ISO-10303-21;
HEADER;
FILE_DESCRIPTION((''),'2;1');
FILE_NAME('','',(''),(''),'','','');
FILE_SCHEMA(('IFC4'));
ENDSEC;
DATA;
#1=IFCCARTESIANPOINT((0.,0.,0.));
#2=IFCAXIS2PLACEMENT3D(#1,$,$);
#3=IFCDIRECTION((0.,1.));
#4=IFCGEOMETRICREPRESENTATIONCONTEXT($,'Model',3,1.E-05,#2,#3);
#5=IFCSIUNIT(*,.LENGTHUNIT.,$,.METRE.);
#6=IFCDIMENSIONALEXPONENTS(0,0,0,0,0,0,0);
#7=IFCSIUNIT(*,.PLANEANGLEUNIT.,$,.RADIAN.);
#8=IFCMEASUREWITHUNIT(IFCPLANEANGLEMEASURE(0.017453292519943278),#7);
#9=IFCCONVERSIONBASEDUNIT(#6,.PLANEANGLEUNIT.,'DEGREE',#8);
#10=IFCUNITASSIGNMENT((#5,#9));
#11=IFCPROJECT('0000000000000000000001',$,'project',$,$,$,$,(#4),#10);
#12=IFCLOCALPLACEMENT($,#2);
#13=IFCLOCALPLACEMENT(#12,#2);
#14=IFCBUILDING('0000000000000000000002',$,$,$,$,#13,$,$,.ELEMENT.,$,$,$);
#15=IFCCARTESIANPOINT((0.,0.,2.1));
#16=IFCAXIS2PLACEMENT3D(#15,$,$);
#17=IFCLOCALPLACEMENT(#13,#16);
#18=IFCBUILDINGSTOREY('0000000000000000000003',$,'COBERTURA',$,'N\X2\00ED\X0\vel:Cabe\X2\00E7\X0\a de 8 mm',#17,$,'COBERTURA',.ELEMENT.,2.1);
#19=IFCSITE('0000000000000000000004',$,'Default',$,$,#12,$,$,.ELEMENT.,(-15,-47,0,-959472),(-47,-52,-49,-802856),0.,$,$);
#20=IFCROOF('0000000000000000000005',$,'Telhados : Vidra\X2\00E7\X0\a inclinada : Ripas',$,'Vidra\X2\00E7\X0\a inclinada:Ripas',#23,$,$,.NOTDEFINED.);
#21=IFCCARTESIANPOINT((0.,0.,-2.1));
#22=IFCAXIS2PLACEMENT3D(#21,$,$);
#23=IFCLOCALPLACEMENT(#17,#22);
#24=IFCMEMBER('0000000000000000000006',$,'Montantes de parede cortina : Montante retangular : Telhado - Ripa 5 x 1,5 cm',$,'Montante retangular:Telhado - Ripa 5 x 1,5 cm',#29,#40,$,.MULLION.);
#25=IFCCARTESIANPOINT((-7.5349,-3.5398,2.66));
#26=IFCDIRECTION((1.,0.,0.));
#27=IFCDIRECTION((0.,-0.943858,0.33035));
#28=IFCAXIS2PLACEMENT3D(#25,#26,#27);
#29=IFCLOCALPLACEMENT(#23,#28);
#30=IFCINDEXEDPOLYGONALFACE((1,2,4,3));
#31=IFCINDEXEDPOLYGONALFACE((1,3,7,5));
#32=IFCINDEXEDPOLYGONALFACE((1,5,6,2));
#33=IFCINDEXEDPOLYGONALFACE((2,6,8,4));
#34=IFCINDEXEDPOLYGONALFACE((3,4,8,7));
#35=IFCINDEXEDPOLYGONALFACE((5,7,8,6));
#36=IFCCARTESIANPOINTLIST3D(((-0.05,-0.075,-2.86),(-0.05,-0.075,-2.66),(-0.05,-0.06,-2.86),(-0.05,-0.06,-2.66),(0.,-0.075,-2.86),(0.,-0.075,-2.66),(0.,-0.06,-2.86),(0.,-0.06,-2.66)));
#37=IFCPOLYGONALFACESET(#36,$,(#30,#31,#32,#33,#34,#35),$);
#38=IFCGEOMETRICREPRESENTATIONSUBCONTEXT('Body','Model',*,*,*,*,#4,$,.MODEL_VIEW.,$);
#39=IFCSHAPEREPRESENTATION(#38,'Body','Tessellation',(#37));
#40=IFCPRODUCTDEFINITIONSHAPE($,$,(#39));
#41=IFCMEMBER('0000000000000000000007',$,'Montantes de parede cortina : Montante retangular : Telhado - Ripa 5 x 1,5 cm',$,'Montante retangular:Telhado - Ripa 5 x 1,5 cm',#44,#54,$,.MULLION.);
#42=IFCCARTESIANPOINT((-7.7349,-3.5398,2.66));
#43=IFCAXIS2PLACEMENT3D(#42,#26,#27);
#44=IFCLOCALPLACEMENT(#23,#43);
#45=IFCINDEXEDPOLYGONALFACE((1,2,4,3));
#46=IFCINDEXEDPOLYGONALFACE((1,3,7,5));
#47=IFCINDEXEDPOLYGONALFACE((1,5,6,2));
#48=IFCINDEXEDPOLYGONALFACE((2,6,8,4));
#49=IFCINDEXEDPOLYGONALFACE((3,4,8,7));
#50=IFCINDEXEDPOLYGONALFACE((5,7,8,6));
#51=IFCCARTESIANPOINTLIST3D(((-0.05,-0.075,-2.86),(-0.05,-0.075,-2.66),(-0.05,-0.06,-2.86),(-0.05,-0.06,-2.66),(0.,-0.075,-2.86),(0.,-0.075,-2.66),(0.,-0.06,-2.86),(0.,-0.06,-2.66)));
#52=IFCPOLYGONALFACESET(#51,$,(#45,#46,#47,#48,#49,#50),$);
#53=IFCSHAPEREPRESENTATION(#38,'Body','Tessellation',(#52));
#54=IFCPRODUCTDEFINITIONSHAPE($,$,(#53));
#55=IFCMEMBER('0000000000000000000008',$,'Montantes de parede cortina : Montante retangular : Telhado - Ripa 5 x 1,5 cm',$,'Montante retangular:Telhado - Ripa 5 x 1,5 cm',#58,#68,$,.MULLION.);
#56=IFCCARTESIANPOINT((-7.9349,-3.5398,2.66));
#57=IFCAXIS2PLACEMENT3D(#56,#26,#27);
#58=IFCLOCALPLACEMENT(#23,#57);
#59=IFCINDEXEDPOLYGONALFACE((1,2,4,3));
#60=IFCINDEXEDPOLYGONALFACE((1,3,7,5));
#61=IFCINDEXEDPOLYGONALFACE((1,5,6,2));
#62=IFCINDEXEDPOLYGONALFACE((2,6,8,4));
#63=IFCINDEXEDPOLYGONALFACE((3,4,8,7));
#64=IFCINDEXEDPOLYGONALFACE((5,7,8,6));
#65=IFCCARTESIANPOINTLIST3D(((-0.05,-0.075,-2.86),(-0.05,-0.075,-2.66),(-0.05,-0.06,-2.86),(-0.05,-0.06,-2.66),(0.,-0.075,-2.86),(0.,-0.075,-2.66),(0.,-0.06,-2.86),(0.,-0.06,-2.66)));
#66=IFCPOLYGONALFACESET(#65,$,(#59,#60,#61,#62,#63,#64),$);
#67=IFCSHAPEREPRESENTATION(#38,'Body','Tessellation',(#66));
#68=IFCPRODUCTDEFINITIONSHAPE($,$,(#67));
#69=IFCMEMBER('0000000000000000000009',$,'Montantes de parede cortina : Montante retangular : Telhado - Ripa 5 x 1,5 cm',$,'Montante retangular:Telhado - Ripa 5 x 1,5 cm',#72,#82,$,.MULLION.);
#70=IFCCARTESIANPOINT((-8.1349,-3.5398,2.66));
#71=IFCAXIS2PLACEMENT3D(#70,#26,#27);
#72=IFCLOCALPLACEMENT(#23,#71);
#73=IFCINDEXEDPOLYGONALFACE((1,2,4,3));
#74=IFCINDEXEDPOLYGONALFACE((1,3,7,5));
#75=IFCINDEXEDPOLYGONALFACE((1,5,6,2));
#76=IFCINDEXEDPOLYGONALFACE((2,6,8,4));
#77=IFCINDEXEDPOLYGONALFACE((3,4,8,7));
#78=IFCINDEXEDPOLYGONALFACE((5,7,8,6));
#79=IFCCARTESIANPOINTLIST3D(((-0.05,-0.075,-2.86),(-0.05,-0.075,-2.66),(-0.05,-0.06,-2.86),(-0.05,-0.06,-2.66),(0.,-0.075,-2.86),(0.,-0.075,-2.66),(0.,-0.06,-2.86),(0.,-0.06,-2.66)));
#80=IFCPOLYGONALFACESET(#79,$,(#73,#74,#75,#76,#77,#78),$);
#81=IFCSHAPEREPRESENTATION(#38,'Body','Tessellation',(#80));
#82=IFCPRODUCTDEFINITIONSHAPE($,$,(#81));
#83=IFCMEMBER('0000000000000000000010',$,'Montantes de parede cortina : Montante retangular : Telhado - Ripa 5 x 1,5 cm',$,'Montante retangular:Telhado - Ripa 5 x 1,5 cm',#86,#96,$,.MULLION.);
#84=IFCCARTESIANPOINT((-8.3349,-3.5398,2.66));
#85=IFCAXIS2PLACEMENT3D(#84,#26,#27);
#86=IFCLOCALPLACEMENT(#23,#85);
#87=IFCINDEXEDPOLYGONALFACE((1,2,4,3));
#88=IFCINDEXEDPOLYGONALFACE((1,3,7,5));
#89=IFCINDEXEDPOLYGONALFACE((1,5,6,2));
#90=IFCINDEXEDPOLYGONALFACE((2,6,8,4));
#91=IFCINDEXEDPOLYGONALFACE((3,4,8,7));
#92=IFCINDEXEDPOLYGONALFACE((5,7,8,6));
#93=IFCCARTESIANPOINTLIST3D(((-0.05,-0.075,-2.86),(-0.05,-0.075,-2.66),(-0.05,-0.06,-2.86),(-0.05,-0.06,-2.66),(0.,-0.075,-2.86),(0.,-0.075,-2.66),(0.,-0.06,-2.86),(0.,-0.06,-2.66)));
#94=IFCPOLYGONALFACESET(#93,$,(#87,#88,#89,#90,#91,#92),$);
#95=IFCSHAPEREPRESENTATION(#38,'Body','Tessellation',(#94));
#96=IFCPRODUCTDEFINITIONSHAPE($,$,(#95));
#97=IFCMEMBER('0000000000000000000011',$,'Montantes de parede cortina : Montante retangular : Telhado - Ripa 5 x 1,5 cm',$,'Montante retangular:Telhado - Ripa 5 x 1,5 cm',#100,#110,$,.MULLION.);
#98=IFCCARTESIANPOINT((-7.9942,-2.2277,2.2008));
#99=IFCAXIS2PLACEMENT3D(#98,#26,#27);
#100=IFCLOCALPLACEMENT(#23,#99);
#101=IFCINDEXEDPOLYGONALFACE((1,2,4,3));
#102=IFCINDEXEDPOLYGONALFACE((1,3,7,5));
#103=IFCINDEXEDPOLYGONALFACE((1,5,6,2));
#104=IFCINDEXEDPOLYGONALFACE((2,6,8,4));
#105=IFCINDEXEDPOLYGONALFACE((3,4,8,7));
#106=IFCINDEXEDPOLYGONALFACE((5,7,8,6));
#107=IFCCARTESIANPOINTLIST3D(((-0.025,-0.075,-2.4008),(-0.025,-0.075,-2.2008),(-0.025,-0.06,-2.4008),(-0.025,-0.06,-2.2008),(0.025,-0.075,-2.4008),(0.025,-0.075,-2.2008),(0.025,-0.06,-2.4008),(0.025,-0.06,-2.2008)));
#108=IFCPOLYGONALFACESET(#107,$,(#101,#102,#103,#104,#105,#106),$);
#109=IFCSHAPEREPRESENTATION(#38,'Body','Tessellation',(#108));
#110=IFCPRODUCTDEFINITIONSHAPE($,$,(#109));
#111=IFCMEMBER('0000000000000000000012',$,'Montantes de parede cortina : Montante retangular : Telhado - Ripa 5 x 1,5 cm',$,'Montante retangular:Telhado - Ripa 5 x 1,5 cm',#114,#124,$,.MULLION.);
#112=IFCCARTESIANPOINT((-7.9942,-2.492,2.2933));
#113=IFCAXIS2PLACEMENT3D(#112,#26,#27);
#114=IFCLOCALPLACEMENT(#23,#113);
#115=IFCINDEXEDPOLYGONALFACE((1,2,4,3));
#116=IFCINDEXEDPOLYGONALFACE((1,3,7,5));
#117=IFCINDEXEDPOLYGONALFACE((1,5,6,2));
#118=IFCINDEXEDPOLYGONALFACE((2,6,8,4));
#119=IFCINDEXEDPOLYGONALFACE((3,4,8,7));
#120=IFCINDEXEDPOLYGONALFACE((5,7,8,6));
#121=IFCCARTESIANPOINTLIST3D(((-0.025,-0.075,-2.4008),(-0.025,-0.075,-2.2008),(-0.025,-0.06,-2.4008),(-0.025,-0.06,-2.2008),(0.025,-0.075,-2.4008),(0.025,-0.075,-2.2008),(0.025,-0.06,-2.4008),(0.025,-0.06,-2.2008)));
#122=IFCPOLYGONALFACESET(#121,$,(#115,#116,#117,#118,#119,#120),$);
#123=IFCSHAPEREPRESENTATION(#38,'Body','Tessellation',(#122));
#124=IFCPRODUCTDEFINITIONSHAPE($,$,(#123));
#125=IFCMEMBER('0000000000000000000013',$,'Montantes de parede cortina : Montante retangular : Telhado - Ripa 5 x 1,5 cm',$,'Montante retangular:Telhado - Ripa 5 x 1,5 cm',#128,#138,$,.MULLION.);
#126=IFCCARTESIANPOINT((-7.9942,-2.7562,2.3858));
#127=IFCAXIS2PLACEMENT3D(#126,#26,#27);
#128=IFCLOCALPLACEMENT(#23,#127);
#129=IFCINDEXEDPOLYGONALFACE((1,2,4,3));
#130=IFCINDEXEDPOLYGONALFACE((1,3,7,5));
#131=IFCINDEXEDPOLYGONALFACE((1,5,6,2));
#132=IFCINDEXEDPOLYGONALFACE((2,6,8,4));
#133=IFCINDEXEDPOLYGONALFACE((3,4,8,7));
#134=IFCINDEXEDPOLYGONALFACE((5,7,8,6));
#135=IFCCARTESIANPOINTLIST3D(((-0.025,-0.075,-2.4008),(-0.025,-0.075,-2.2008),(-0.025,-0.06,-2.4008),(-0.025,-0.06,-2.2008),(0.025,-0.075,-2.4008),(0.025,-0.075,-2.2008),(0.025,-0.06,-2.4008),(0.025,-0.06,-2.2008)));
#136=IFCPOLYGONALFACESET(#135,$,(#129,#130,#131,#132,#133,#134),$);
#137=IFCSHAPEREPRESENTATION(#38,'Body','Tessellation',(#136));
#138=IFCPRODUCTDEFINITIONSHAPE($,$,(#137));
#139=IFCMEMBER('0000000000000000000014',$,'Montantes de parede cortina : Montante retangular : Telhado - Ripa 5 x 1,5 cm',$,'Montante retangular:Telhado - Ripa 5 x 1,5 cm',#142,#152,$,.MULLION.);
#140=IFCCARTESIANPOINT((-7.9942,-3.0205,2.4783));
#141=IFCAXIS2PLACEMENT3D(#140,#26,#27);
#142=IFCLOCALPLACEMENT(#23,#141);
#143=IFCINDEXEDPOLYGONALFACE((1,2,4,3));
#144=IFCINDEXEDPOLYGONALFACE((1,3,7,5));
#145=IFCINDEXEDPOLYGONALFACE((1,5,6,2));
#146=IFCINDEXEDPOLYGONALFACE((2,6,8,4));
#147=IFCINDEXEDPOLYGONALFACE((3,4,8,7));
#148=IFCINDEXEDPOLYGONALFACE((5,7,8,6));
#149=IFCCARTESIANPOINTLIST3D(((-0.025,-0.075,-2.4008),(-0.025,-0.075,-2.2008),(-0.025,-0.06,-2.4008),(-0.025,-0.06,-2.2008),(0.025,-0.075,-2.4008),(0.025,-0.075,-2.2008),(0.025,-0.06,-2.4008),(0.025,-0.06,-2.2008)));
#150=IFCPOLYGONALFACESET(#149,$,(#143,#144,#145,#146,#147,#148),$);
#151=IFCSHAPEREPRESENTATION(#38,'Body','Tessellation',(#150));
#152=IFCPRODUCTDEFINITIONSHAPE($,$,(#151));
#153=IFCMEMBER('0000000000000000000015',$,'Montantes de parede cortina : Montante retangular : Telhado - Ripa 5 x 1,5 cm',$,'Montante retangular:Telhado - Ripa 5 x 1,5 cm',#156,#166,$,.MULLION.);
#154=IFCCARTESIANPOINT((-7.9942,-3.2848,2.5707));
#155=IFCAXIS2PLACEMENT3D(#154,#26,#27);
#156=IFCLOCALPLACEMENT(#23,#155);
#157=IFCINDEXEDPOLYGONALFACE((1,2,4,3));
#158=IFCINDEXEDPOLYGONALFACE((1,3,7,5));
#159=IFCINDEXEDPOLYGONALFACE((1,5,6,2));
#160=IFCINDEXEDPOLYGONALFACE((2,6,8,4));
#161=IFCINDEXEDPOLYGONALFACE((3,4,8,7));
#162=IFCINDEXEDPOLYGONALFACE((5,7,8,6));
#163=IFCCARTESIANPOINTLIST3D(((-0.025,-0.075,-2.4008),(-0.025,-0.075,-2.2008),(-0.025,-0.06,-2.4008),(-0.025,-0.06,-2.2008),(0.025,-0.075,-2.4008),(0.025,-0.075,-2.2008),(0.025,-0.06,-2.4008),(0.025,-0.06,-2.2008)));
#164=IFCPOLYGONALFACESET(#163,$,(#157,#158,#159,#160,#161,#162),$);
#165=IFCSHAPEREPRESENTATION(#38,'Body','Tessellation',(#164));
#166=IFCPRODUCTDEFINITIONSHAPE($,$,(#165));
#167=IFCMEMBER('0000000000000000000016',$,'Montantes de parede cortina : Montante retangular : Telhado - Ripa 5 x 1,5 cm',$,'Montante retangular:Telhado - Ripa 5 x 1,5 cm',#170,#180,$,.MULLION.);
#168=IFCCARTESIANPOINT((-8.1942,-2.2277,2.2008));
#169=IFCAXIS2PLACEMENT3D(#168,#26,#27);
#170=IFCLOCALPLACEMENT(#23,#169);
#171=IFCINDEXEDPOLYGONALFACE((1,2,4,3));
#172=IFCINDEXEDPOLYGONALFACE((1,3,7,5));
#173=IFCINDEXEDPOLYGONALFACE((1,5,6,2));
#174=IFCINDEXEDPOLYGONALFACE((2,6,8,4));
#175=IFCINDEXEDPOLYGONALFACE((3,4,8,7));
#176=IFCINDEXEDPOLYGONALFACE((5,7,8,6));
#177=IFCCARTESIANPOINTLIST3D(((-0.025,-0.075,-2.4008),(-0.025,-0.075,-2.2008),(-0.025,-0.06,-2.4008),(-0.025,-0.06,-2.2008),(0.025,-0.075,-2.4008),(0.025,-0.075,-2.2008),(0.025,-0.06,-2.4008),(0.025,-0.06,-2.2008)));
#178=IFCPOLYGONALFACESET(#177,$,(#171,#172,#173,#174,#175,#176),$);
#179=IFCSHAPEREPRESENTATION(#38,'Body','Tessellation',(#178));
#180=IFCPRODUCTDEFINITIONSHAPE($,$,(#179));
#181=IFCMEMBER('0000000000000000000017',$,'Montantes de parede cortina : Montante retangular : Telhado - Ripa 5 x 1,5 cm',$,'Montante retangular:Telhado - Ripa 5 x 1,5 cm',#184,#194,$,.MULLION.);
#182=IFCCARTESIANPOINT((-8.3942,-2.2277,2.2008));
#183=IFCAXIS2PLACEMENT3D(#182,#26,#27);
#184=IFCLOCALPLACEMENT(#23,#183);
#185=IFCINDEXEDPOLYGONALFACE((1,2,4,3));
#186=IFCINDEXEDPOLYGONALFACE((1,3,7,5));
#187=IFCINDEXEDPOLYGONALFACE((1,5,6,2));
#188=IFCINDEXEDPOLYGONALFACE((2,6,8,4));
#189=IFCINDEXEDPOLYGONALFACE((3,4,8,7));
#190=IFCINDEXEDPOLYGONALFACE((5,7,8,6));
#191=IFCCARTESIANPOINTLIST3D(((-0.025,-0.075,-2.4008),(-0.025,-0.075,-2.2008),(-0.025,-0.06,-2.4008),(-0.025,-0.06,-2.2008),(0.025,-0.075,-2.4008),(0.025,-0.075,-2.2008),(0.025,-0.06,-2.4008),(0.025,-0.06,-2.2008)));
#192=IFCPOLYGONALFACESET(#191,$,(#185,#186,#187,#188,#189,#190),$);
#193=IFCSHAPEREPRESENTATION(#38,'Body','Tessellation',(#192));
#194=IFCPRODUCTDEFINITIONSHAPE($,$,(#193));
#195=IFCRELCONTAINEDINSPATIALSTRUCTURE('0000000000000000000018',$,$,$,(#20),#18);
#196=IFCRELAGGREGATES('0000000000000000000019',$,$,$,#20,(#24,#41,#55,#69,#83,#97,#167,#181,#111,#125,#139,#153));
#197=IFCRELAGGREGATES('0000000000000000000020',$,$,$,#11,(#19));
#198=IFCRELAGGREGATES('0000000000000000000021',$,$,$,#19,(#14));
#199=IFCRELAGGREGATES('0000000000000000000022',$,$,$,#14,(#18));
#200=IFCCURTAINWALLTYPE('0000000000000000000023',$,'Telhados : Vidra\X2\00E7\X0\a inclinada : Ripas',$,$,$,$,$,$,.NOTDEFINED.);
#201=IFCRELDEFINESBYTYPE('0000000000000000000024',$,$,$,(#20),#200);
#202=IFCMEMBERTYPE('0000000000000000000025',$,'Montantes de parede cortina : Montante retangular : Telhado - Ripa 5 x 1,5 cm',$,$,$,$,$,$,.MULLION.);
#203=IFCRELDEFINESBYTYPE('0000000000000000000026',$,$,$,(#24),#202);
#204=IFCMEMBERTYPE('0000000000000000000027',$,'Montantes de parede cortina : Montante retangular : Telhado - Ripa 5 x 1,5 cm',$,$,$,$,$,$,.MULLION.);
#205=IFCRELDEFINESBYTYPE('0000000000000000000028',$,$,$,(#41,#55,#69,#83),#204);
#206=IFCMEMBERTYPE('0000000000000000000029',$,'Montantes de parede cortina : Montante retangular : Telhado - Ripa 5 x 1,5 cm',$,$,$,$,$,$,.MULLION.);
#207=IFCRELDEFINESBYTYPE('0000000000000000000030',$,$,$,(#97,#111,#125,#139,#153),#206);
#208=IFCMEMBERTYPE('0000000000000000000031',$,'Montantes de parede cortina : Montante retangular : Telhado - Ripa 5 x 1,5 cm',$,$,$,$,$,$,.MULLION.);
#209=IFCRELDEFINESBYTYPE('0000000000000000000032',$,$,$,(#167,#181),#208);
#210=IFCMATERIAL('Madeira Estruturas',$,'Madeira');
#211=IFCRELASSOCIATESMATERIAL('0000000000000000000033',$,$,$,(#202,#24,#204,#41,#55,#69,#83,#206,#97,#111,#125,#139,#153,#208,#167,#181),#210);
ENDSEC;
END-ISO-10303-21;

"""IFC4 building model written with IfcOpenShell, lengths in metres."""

from ifc_helpers import new_model, entity, si_unit, converted_unit, direction, frame, origin, place, context, subcontext, project, spatial, indexed_curve, outline, extrude, source, transform, mapped, material, type_object, type_shapes, element, aggregate, save


model = new_model("IFC4")

# Units and contexts
model_context = context("Model", 3, precision=1e-05, world=origin(), true_north=direction((0.0, 1.0)))
body_context = subcontext(model_context, "Body", "Model", "MODEL_VIEW")
ifc_project = project(units=[si_unit("LENGTHUNIT", "METRE"), converted_unit("PLANEANGLEUNIT", "DEGREE", entity("IfcPlaneAngleMeasure", 0.017453292519943278), si_unit("PLANEANGLEUNIT", "RADIAN"), dimensions=[0, 0, 0, 0, 0, 0, 0])], contexts=[model_context])

# Site, building, storey
site_placement = place(None, origin())
site = spatial("IfcSite", under=ifc_project, at=site_placement, Name="Default", CompositionType="ELEMENT", RefLatitude=(-15, -47, 0, -959472), RefLongitude=(-47, -52, -49, -802856), RefElevation=0.0)
building_placement = place(site_placement, origin())
building = spatial("IfcBuilding", under=site, at=building_placement, CompositionType="ELEMENT")
storey_placement = place(building_placement, frame((0.0, 0.0, 2.1)))
storey = spatial("IfcBuildingStorey", under=building, at=storey_placement, Name="COBERTURA", ObjectType="Nível:Cabeça de 8 mm", LongName="COBERTURA", CompositionType="ELEMENT", Elevation=2.1)

# Roof, members
curtain_wall_type = type_object("IfcCurtainWallType", Name="Telhados : Vidraça inclinada : Ripas", PredefinedType="NOTDEFINED")
roof_placement = place(storey_placement, frame((0.0, 0.0, -2.1)))
roof = element("IfcRoof", 1, at=roof_placement, inside=storey, type_object=curtain_wall_type, Name="Telhados : Vidraça inclinada : Ripas", ObjectType="Vidraça inclinada:Ripas", PredefinedType="NOTDEFINED")
ifc_material_1 = material(Name="Madeira Estruturas", Category="Madeira")
member_type_1 = type_object("IfcMemberType", Name="Montantes de parede cortina : Montante retangular : Telhado - Ripa 5 x 1,5 cm", PredefinedType="MULLION", material=ifc_material_1)
shared_shape_1 = source(origin(), body_context, "Body", "SweptSolid", [
    extrude(outline(indexed_curve([(-0.025, -0.0075), (0.025, -0.0075), (0.025, 0.0075), (-0.025, 0.0075), (-0.025, -0.0075)], self_intersect=False)), frame((-0.025, -0.0675, -2.86), z_axis=(0.0, 0.0, 1.0), x_axis=(-1.0, 0.0, 0.0)), (0.0, 0.0, 1.0), 0.2),
])
type_shapes(member_type_1, [shared_shape_1])
member_1_placement = place(roof_placement, frame((-7.5349, -3.5398, 2.66), z_axis=(1.0, 0.0, 0.0), x_axis=(0.0, -0.943858, 0.33035)))
member_1 = element("IfcMember", 2, at=member_1_placement, type_object=member_type_1, material=ifc_material_1, Name="Montantes de parede cortina : Montante retangular : Telhado - Ripa 5 x 1,5 cm", ObjectType="Montante retangular:Telhado - Ripa 5 x 1,5 cm", PredefinedType="MULLION", context=body_context, shape_type="MappedRepresentation", body=[
    mapped(shared_shape_1, transform((0.0, 0.0, 0.0), scale=1.0)),
])
member_type_2 = type_object("IfcMemberType", Name="Montantes de parede cortina : Montante retangular : Telhado - Ripa 5 x 1,5 cm", PredefinedType="MULLION", material=ifc_material_1)
shared_shape_2 = source(origin(), body_context, "Body", "SweptSolid", [
    extrude(outline(indexed_curve([(-0.025, -0.0075), (0.025, -0.0075), (0.025, 0.0075), (-0.025, 0.0075), (-0.025, -0.0075)], self_intersect=False)), frame((-0.025, -0.0675, -2.86), z_axis=(0.0, 0.0, 1.0), x_axis=(-1.0, 0.0, 0.0)), (0.0, 0.0, 1.0), 0.2),
])
type_shapes(member_type_2, [shared_shape_2])
member_2_placement = place(roof_placement, frame((-7.7349, -3.5398, 2.66), z_axis=(1.0, 0.0, 0.0), x_axis=(0.0, -0.943858, 0.33035)))
member_2 = element("IfcMember", 3, at=member_2_placement, type_object=member_type_2, material=ifc_material_1, Name="Montantes de parede cortina : Montante retangular : Telhado - Ripa 5 x 1,5 cm", ObjectType="Montante retangular:Telhado - Ripa 5 x 1,5 cm", PredefinedType="MULLION", context=body_context, shape_type="MappedRepresentation", body=[
    mapped(shared_shape_2, transform((0.0, 0.0, 0.0), scale=1.0)),
])
member_3_placement = place(roof_placement, frame((-7.9349, -3.5398, 2.66), z_axis=(1.0, 0.0, 0.0), x_axis=(0.0, -0.943858, 0.33035)))
member_3 = element("IfcMember", 4, at=member_3_placement, type_object=member_type_2, material=ifc_material_1, Name="Montantes de parede cortina : Montante retangular : Telhado - Ripa 5 x 1,5 cm", ObjectType="Montante retangular:Telhado - Ripa 5 x 1,5 cm", PredefinedType="MULLION", context=body_context, shape_type="MappedRepresentation", body=[
    mapped(shared_shape_2, transform((0.0, 0.0, 0.0), scale=1.0)),
])
member_4_placement = place(roof_placement, frame((-8.1349, -3.5398, 2.66), z_axis=(1.0, 0.0, 0.0), x_axis=(0.0, -0.943858, 0.33035)))
member_4 = element("IfcMember", 5, at=member_4_placement, type_object=member_type_2, material=ifc_material_1, Name="Montantes de parede cortina : Montante retangular : Telhado - Ripa 5 x 1,5 cm", ObjectType="Montante retangular:Telhado - Ripa 5 x 1,5 cm", PredefinedType="MULLION", context=body_context, shape_type="MappedRepresentation", body=[
    mapped(shared_shape_2, transform((0.0, 0.0, 0.0), scale=1.0)),
])
member_5_placement = place(roof_placement, frame((-8.3349, -3.5398, 2.66), z_axis=(1.0, 0.0, 0.0), x_axis=(0.0, -0.943858, 0.33035)))
member_5 = element("IfcMember", 6, at=member_5_placement, type_object=member_type_2, material=ifc_material_1, Name="Montantes de parede cortina : Montante retangular : Telhado - Ripa 5 x 1,5 cm", ObjectType="Montante retangular:Telhado - Ripa 5 x 1,5 cm", PredefinedType="MULLION", context=body_context, shape_type="MappedRepresentation", body=[
    mapped(shared_shape_2, transform((0.0, 0.0, 0.0), scale=1.0)),
])
member_type_3 = type_object("IfcMemberType", Name="Montantes de parede cortina : Montante retangular : Telhado - Ripa 5 x 1,5 cm", PredefinedType="MULLION", material=ifc_material_1)
shared_shape_3 = source(origin(), body_context, "Body", "SweptSolid", [
    extrude(outline(indexed_curve([(-0.025, -0.0075), (0.025, -0.0075), (0.025, 0.0075), (-0.025, 0.0075), (-0.025, -0.0075)], self_intersect=False)), frame((0.0, -0.0675, -2.4008), z_axis=(0.0, 0.0, 1.0), x_axis=(-1.0, 0.0, 0.0)), (0.0, 0.0, 1.0), 0.2),
])
type_shapes(member_type_3, [shared_shape_3])
member_6_placement = place(roof_placement, frame((-7.9942, -2.2277, 2.2008), z_axis=(1.0, 0.0, 0.0), x_axis=(0.0, -0.943858, 0.33035)))
member_6 = element("IfcMember", 7, at=member_6_placement, type_object=member_type_3, material=ifc_material_1, Name="Montantes de parede cortina : Montante retangular : Telhado - Ripa 5 x 1,5 cm", ObjectType="Montante retangular:Telhado - Ripa 5 x 1,5 cm", PredefinedType="MULLION", context=body_context, shape_type="MappedRepresentation", body=[
    mapped(shared_shape_3, transform((0.0, 0.0, 0.0), scale=1.0)),
])
member_7_placement = place(roof_placement, frame((-7.9942, -2.492, 2.2933), z_axis=(1.0, 0.0, 0.0), x_axis=(0.0, -0.943858, 0.33035)))
member_7 = element("IfcMember", 8, at=member_7_placement, type_object=member_type_3, material=ifc_material_1, Name="Montantes de parede cortina : Montante retangular : Telhado - Ripa 5 x 1,5 cm", ObjectType="Montante retangular:Telhado - Ripa 5 x 1,5 cm", PredefinedType="MULLION", context=body_context, shape_type="MappedRepresentation", body=[
    mapped(shared_shape_3, transform((0.0, 0.0, 0.0), scale=1.0)),
])
member_8_placement = place(roof_placement, frame((-7.9942, -2.7562, 2.3858), z_axis=(1.0, 0.0, 0.0), x_axis=(0.0, -0.943858, 0.33035)))
member_8 = element("IfcMember", 9, at=member_8_placement, type_object=member_type_3, material=ifc_material_1, Name="Montantes de parede cortina : Montante retangular : Telhado - Ripa 5 x 1,5 cm", ObjectType="Montante retangular:Telhado - Ripa 5 x 1,5 cm", PredefinedType="MULLION", context=body_context, shape_type="MappedRepresentation", body=[
    mapped(shared_shape_3, transform((0.0, 0.0, 0.0), scale=1.0)),
])
member_9_placement = place(roof_placement, frame((-7.9942, -3.0205, 2.4783), z_axis=(1.0, 0.0, 0.0), x_axis=(0.0, -0.943858, 0.33035)))
member_9 = element("IfcMember", 10, at=member_9_placement, type_object=member_type_3, material=ifc_material_1, Name="Montantes de parede cortina : Montante retangular : Telhado - Ripa 5 x 1,5 cm", ObjectType="Montante retangular:Telhado - Ripa 5 x 1,5 cm", PredefinedType="MULLION", context=body_context, shape_type="MappedRepresentation", body=[
    mapped(shared_shape_3, transform((0.0, 0.0, 0.0), scale=1.0)),
])
member_10_placement = place(roof_placement, frame((-7.9942, -3.2848, 2.5707), z_axis=(1.0, 0.0, 0.0), x_axis=(0.0, -0.943858, 0.33035)))
member_10 = element("IfcMember", 11, at=member_10_placement, type_object=member_type_3, material=ifc_material_1, Name="Montantes de parede cortina : Montante retangular : Telhado - Ripa 5 x 1,5 cm", ObjectType="Montante retangular:Telhado - Ripa 5 x 1,5 cm", PredefinedType="MULLION", context=body_context, shape_type="MappedRepresentation", body=[
    mapped(shared_shape_3, transform((0.0, 0.0, 0.0), scale=1.0)),
])
member_type_4 = type_object("IfcMemberType", Name="Montantes de parede cortina : Montante retangular : Telhado - Ripa 5 x 1,5 cm", PredefinedType="MULLION", material=ifc_material_1)
shared_shape_4 = source(origin(), body_context, "Body", "SweptSolid", [
    extrude(outline(indexed_curve([(-0.025, -0.0075), (0.025, -0.0075), (0.025, 0.0075), (-0.025, 0.0075), (-0.025, -0.0075)], self_intersect=False)), frame((0.0, -0.0675, -2.4008), z_axis=(0.0, 0.0, 1.0), x_axis=(-1.0, 0.0, 0.0)), (0.0, 0.0, 1.0), 0.2),
])
type_shapes(member_type_4, [shared_shape_4])
member_11_placement = place(roof_placement, frame((-8.1942, -2.2277, 2.2008), z_axis=(1.0, 0.0, 0.0), x_axis=(0.0, -0.943858, 0.33035)))
member_11 = element("IfcMember", 12, at=member_11_placement, type_object=member_type_4, material=ifc_material_1, Name="Montantes de parede cortina : Montante retangular : Telhado - Ripa 5 x 1,5 cm", ObjectType="Montante retangular:Telhado - Ripa 5 x 1,5 cm", PredefinedType="MULLION", context=body_context, shape_type="MappedRepresentation", body=[
    mapped(shared_shape_4, transform((0.0, 0.0, 0.0), scale=1.0)),
])
member_12_placement = place(roof_placement, frame((-8.3942, -2.2277, 2.2008), z_axis=(1.0, 0.0, 0.0), x_axis=(0.0, -0.943858, 0.33035)))
member_12 = element("IfcMember", 13, at=member_12_placement, type_object=member_type_4, material=ifc_material_1, Name="Montantes de parede cortina : Montante retangular : Telhado - Ripa 5 x 1,5 cm", ObjectType="Montante retangular:Telhado - Ripa 5 x 1,5 cm", PredefinedType="MULLION", context=body_context, shape_type="MappedRepresentation", body=[
    mapped(shared_shape_4, transform((0.0, 0.0, 0.0), scale=1.0)),
])
aggregate(roof, [member_1, member_2, member_3, member_4, member_5, member_6, member_11, member_12, member_7, member_8, member_9, member_10])

save(model, "model.ifc")
